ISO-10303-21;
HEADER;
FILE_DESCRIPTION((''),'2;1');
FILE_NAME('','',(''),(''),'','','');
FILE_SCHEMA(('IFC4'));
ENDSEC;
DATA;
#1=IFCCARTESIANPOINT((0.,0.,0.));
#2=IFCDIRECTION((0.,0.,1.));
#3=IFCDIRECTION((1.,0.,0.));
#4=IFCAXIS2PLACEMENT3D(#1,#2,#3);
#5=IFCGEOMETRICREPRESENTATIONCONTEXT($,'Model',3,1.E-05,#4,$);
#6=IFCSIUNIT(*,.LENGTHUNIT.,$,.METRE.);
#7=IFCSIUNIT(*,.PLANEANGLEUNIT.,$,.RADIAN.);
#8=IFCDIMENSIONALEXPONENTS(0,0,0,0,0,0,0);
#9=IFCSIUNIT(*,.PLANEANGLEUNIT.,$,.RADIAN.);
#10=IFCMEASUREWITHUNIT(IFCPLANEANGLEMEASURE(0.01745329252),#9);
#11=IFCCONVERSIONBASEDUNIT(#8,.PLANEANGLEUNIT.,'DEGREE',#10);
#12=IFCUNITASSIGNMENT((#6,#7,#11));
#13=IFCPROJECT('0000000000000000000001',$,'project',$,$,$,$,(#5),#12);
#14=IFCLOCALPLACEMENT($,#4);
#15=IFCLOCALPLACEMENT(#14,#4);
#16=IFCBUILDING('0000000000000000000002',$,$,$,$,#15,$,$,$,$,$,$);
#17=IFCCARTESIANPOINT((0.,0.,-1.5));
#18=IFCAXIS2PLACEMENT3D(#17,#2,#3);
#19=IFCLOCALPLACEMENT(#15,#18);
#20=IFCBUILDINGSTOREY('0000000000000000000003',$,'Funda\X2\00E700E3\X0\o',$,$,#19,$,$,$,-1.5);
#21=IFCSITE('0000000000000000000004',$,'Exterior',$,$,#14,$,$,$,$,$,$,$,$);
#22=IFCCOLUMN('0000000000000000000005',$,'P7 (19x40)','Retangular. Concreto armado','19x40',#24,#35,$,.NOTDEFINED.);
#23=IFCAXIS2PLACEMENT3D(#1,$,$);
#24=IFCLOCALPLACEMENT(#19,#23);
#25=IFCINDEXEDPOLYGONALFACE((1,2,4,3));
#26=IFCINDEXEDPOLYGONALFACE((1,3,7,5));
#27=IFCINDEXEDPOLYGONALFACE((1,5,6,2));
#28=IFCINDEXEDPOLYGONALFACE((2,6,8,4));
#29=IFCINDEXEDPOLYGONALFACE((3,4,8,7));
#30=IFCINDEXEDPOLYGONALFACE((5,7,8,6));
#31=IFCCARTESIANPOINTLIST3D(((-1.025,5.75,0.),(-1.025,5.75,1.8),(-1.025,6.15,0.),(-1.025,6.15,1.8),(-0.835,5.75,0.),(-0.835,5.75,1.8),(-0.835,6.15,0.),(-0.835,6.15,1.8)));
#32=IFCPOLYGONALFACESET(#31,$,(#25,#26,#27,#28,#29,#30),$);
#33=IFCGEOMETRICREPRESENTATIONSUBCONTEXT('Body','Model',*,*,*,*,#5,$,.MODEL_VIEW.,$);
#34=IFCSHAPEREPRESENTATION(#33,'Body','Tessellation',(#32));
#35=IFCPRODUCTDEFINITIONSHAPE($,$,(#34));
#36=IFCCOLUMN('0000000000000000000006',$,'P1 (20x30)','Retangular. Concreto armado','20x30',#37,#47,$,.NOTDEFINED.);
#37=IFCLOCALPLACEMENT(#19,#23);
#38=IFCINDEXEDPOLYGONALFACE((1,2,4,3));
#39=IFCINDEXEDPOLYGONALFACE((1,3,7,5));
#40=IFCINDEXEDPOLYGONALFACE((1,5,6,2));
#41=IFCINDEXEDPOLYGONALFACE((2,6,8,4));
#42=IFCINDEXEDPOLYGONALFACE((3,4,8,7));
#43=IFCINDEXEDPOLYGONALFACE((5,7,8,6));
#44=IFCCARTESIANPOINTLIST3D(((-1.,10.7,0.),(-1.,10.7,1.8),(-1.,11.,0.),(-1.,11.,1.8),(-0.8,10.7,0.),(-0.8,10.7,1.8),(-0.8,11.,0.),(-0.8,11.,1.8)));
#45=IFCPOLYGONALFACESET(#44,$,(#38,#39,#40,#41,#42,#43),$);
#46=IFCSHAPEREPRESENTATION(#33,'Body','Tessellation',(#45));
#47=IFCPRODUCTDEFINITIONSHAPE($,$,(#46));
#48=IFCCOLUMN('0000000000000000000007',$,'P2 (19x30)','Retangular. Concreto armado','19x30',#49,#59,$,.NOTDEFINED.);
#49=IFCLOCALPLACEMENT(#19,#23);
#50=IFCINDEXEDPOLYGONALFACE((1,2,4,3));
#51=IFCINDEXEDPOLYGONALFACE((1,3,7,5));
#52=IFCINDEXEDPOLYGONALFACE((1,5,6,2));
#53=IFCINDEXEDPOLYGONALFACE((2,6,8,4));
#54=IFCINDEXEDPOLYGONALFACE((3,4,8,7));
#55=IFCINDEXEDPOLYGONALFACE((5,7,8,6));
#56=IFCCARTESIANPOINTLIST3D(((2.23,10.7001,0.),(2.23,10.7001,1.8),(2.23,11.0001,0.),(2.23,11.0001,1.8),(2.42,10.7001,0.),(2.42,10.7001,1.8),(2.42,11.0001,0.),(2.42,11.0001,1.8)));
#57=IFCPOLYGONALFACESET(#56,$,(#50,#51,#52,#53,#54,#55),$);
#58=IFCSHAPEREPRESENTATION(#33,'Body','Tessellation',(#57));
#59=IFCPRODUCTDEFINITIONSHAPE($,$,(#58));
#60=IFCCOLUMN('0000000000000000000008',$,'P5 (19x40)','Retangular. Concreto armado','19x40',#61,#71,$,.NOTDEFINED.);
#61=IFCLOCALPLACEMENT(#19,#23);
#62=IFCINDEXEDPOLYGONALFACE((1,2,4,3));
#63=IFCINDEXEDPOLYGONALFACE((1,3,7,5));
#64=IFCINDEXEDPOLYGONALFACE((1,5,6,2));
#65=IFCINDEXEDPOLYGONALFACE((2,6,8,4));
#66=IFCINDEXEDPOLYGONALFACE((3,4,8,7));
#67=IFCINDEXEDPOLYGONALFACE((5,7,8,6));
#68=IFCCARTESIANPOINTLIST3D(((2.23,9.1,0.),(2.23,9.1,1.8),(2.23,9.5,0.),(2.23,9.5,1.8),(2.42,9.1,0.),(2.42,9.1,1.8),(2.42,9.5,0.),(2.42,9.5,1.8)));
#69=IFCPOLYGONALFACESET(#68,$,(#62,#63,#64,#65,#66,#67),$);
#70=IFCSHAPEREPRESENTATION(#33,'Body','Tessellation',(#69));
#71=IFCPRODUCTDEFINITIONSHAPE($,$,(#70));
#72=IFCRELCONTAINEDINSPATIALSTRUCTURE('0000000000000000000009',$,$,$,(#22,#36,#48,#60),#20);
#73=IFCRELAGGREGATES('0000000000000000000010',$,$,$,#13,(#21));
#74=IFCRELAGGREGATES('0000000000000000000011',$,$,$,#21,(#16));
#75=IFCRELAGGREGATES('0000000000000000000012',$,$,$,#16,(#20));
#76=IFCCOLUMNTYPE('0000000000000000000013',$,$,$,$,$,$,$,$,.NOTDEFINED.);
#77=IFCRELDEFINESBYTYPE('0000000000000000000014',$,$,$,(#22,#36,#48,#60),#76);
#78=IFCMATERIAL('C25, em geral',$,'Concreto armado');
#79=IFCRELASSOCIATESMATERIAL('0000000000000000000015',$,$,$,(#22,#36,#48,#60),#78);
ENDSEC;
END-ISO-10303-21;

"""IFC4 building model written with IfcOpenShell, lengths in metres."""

from ifc_helpers import new_model, entity, si_unit, converted_unit, frame, frame_2d, origin_with_axes, origin_2d_with_axis, place, context, subcontext, project, spatial, rectangle, extrude, material, type_object, element, save


model = new_model("IFC4")

# Units and contexts
model_context = context("Model", 3, precision=1e-05, world=origin_with_axes())
body_context = subcontext(model_context, "Body", "Model", "MODEL_VIEW")
ifc_project = project(units=[si_unit("LENGTHUNIT", "METRE"), si_unit("PLANEANGLEUNIT", "RADIAN"), converted_unit("PLANEANGLEUNIT", "DEGREE", entity("IfcPlaneAngleMeasure", 0.01745329252), si_unit("PLANEANGLEUNIT", "RADIAN"), dimensions=[0, 0, 0, 0, 0, 0, 0])], contexts=[model_context])

# Site, building, storey
site_placement = place(None, origin_with_axes())
site = spatial("IfcSite", under=ifc_project, at=site_placement, Name="Exterior")
building_placement = place(site_placement, origin_with_axes())
building = spatial("IfcBuilding", under=site, at=building_placement)
storey_placement = place(building_placement, frame((0.0, 0.0, -1.5), z_axis=(0.0, 0.0, 1.0), x_axis=(1.0, 0.0, 0.0)))
storey = spatial("IfcBuildingStorey", under=building, at=storey_placement, Name="Fundação", Elevation=-1.5)

# Shared definitions
ifc_material = material(Name="C25, em geral", Category="Concreto armado")

# Columns
column_type = type_object("IfcColumnType", PredefinedType="NOTDEFINED")
column_1_placement = place(storey_placement, frame((-0.93, 6.15, 0.0), z_axis=(0.0, 0.0, 1.0), x_axis=(1.0, 0.0, 0.0)))
element("IfcColumn", 1, at=column_1_placement, inside=storey, type_object=column_type, material=ifc_material, Name="P7 (19x40)", Description="Retangular. Concreto armado", ObjectType="19x40", PredefinedType="NOTDEFINED", context=body_context, shape_type="SweptSolid", body=[
    extrude(rectangle(XDim=0.19, YDim=0.4, at=frame_2d((0.0, -0.2), x_axis=(1.0, 0.0))), origin_with_axes(), (0.0, 0.0, 1.0), 1.8),
])
column_2_placement = place(storey_placement, frame((-1.0, 11.0, 0.0), z_axis=(0.0, 0.0, 1.0), x_axis=(1.0, 0.0, 0.0)))
element("IfcColumn", 2, at=column_2_placement, inside=storey, type_object=column_type, material=ifc_material, Name="P1 (20x30)", Description="Retangular. Concreto armado", ObjectType="20x30", PredefinedType="NOTDEFINED", context=body_context, shape_type="SweptSolid", body=[
    extrude(rectangle(XDim=0.2, YDim=0.3, at=frame_2d((0.1, -0.15), x_axis=(1.0, 0.0))), origin_with_axes(), (0.0, 0.0, 1.0), 1.8),
])
column_3_placement = place(storey_placement, frame((2.325, 10.8501, 0.0), z_axis=(0.0, 0.0, 1.0), x_axis=(1.0, 0.0, 0.0)))
element("IfcColumn", 3, at=column_3_placement, inside=storey, type_object=column_type, material=ifc_material, Name="P2 (19x30)", Description="Retangular. Concreto armado", ObjectType="19x30", PredefinedType="NOTDEFINED", context=body_context, shape_type="SweptSolid", body=[
    extrude(rectangle(XDim=0.19, YDim=0.3, at=origin_2d_with_axis()), origin_with_axes(), (0.0, 0.0, 1.0), 1.8),
])
column_4_placement = place(storey_placement, frame((2.325, 9.1, 0.0), z_axis=(0.0, 0.0, 1.0), x_axis=(1.0, 0.0, 0.0)))
element("IfcColumn", 4, at=column_4_placement, inside=storey, type_object=column_type, material=ifc_material, Name="P5 (19x40)", Description="Retangular. Concreto armado", ObjectType="19x40", PredefinedType="NOTDEFINED", context=body_context, shape_type="SweptSolid", body=[
    extrude(rectangle(XDim=0.19, YDim=0.4, at=frame_2d((0.0, 0.2), x_axis=(1.0, 0.0))), origin_with_axes(), (0.0, 0.0, 1.0), 1.8),
])

save(model, "model.ifc")
